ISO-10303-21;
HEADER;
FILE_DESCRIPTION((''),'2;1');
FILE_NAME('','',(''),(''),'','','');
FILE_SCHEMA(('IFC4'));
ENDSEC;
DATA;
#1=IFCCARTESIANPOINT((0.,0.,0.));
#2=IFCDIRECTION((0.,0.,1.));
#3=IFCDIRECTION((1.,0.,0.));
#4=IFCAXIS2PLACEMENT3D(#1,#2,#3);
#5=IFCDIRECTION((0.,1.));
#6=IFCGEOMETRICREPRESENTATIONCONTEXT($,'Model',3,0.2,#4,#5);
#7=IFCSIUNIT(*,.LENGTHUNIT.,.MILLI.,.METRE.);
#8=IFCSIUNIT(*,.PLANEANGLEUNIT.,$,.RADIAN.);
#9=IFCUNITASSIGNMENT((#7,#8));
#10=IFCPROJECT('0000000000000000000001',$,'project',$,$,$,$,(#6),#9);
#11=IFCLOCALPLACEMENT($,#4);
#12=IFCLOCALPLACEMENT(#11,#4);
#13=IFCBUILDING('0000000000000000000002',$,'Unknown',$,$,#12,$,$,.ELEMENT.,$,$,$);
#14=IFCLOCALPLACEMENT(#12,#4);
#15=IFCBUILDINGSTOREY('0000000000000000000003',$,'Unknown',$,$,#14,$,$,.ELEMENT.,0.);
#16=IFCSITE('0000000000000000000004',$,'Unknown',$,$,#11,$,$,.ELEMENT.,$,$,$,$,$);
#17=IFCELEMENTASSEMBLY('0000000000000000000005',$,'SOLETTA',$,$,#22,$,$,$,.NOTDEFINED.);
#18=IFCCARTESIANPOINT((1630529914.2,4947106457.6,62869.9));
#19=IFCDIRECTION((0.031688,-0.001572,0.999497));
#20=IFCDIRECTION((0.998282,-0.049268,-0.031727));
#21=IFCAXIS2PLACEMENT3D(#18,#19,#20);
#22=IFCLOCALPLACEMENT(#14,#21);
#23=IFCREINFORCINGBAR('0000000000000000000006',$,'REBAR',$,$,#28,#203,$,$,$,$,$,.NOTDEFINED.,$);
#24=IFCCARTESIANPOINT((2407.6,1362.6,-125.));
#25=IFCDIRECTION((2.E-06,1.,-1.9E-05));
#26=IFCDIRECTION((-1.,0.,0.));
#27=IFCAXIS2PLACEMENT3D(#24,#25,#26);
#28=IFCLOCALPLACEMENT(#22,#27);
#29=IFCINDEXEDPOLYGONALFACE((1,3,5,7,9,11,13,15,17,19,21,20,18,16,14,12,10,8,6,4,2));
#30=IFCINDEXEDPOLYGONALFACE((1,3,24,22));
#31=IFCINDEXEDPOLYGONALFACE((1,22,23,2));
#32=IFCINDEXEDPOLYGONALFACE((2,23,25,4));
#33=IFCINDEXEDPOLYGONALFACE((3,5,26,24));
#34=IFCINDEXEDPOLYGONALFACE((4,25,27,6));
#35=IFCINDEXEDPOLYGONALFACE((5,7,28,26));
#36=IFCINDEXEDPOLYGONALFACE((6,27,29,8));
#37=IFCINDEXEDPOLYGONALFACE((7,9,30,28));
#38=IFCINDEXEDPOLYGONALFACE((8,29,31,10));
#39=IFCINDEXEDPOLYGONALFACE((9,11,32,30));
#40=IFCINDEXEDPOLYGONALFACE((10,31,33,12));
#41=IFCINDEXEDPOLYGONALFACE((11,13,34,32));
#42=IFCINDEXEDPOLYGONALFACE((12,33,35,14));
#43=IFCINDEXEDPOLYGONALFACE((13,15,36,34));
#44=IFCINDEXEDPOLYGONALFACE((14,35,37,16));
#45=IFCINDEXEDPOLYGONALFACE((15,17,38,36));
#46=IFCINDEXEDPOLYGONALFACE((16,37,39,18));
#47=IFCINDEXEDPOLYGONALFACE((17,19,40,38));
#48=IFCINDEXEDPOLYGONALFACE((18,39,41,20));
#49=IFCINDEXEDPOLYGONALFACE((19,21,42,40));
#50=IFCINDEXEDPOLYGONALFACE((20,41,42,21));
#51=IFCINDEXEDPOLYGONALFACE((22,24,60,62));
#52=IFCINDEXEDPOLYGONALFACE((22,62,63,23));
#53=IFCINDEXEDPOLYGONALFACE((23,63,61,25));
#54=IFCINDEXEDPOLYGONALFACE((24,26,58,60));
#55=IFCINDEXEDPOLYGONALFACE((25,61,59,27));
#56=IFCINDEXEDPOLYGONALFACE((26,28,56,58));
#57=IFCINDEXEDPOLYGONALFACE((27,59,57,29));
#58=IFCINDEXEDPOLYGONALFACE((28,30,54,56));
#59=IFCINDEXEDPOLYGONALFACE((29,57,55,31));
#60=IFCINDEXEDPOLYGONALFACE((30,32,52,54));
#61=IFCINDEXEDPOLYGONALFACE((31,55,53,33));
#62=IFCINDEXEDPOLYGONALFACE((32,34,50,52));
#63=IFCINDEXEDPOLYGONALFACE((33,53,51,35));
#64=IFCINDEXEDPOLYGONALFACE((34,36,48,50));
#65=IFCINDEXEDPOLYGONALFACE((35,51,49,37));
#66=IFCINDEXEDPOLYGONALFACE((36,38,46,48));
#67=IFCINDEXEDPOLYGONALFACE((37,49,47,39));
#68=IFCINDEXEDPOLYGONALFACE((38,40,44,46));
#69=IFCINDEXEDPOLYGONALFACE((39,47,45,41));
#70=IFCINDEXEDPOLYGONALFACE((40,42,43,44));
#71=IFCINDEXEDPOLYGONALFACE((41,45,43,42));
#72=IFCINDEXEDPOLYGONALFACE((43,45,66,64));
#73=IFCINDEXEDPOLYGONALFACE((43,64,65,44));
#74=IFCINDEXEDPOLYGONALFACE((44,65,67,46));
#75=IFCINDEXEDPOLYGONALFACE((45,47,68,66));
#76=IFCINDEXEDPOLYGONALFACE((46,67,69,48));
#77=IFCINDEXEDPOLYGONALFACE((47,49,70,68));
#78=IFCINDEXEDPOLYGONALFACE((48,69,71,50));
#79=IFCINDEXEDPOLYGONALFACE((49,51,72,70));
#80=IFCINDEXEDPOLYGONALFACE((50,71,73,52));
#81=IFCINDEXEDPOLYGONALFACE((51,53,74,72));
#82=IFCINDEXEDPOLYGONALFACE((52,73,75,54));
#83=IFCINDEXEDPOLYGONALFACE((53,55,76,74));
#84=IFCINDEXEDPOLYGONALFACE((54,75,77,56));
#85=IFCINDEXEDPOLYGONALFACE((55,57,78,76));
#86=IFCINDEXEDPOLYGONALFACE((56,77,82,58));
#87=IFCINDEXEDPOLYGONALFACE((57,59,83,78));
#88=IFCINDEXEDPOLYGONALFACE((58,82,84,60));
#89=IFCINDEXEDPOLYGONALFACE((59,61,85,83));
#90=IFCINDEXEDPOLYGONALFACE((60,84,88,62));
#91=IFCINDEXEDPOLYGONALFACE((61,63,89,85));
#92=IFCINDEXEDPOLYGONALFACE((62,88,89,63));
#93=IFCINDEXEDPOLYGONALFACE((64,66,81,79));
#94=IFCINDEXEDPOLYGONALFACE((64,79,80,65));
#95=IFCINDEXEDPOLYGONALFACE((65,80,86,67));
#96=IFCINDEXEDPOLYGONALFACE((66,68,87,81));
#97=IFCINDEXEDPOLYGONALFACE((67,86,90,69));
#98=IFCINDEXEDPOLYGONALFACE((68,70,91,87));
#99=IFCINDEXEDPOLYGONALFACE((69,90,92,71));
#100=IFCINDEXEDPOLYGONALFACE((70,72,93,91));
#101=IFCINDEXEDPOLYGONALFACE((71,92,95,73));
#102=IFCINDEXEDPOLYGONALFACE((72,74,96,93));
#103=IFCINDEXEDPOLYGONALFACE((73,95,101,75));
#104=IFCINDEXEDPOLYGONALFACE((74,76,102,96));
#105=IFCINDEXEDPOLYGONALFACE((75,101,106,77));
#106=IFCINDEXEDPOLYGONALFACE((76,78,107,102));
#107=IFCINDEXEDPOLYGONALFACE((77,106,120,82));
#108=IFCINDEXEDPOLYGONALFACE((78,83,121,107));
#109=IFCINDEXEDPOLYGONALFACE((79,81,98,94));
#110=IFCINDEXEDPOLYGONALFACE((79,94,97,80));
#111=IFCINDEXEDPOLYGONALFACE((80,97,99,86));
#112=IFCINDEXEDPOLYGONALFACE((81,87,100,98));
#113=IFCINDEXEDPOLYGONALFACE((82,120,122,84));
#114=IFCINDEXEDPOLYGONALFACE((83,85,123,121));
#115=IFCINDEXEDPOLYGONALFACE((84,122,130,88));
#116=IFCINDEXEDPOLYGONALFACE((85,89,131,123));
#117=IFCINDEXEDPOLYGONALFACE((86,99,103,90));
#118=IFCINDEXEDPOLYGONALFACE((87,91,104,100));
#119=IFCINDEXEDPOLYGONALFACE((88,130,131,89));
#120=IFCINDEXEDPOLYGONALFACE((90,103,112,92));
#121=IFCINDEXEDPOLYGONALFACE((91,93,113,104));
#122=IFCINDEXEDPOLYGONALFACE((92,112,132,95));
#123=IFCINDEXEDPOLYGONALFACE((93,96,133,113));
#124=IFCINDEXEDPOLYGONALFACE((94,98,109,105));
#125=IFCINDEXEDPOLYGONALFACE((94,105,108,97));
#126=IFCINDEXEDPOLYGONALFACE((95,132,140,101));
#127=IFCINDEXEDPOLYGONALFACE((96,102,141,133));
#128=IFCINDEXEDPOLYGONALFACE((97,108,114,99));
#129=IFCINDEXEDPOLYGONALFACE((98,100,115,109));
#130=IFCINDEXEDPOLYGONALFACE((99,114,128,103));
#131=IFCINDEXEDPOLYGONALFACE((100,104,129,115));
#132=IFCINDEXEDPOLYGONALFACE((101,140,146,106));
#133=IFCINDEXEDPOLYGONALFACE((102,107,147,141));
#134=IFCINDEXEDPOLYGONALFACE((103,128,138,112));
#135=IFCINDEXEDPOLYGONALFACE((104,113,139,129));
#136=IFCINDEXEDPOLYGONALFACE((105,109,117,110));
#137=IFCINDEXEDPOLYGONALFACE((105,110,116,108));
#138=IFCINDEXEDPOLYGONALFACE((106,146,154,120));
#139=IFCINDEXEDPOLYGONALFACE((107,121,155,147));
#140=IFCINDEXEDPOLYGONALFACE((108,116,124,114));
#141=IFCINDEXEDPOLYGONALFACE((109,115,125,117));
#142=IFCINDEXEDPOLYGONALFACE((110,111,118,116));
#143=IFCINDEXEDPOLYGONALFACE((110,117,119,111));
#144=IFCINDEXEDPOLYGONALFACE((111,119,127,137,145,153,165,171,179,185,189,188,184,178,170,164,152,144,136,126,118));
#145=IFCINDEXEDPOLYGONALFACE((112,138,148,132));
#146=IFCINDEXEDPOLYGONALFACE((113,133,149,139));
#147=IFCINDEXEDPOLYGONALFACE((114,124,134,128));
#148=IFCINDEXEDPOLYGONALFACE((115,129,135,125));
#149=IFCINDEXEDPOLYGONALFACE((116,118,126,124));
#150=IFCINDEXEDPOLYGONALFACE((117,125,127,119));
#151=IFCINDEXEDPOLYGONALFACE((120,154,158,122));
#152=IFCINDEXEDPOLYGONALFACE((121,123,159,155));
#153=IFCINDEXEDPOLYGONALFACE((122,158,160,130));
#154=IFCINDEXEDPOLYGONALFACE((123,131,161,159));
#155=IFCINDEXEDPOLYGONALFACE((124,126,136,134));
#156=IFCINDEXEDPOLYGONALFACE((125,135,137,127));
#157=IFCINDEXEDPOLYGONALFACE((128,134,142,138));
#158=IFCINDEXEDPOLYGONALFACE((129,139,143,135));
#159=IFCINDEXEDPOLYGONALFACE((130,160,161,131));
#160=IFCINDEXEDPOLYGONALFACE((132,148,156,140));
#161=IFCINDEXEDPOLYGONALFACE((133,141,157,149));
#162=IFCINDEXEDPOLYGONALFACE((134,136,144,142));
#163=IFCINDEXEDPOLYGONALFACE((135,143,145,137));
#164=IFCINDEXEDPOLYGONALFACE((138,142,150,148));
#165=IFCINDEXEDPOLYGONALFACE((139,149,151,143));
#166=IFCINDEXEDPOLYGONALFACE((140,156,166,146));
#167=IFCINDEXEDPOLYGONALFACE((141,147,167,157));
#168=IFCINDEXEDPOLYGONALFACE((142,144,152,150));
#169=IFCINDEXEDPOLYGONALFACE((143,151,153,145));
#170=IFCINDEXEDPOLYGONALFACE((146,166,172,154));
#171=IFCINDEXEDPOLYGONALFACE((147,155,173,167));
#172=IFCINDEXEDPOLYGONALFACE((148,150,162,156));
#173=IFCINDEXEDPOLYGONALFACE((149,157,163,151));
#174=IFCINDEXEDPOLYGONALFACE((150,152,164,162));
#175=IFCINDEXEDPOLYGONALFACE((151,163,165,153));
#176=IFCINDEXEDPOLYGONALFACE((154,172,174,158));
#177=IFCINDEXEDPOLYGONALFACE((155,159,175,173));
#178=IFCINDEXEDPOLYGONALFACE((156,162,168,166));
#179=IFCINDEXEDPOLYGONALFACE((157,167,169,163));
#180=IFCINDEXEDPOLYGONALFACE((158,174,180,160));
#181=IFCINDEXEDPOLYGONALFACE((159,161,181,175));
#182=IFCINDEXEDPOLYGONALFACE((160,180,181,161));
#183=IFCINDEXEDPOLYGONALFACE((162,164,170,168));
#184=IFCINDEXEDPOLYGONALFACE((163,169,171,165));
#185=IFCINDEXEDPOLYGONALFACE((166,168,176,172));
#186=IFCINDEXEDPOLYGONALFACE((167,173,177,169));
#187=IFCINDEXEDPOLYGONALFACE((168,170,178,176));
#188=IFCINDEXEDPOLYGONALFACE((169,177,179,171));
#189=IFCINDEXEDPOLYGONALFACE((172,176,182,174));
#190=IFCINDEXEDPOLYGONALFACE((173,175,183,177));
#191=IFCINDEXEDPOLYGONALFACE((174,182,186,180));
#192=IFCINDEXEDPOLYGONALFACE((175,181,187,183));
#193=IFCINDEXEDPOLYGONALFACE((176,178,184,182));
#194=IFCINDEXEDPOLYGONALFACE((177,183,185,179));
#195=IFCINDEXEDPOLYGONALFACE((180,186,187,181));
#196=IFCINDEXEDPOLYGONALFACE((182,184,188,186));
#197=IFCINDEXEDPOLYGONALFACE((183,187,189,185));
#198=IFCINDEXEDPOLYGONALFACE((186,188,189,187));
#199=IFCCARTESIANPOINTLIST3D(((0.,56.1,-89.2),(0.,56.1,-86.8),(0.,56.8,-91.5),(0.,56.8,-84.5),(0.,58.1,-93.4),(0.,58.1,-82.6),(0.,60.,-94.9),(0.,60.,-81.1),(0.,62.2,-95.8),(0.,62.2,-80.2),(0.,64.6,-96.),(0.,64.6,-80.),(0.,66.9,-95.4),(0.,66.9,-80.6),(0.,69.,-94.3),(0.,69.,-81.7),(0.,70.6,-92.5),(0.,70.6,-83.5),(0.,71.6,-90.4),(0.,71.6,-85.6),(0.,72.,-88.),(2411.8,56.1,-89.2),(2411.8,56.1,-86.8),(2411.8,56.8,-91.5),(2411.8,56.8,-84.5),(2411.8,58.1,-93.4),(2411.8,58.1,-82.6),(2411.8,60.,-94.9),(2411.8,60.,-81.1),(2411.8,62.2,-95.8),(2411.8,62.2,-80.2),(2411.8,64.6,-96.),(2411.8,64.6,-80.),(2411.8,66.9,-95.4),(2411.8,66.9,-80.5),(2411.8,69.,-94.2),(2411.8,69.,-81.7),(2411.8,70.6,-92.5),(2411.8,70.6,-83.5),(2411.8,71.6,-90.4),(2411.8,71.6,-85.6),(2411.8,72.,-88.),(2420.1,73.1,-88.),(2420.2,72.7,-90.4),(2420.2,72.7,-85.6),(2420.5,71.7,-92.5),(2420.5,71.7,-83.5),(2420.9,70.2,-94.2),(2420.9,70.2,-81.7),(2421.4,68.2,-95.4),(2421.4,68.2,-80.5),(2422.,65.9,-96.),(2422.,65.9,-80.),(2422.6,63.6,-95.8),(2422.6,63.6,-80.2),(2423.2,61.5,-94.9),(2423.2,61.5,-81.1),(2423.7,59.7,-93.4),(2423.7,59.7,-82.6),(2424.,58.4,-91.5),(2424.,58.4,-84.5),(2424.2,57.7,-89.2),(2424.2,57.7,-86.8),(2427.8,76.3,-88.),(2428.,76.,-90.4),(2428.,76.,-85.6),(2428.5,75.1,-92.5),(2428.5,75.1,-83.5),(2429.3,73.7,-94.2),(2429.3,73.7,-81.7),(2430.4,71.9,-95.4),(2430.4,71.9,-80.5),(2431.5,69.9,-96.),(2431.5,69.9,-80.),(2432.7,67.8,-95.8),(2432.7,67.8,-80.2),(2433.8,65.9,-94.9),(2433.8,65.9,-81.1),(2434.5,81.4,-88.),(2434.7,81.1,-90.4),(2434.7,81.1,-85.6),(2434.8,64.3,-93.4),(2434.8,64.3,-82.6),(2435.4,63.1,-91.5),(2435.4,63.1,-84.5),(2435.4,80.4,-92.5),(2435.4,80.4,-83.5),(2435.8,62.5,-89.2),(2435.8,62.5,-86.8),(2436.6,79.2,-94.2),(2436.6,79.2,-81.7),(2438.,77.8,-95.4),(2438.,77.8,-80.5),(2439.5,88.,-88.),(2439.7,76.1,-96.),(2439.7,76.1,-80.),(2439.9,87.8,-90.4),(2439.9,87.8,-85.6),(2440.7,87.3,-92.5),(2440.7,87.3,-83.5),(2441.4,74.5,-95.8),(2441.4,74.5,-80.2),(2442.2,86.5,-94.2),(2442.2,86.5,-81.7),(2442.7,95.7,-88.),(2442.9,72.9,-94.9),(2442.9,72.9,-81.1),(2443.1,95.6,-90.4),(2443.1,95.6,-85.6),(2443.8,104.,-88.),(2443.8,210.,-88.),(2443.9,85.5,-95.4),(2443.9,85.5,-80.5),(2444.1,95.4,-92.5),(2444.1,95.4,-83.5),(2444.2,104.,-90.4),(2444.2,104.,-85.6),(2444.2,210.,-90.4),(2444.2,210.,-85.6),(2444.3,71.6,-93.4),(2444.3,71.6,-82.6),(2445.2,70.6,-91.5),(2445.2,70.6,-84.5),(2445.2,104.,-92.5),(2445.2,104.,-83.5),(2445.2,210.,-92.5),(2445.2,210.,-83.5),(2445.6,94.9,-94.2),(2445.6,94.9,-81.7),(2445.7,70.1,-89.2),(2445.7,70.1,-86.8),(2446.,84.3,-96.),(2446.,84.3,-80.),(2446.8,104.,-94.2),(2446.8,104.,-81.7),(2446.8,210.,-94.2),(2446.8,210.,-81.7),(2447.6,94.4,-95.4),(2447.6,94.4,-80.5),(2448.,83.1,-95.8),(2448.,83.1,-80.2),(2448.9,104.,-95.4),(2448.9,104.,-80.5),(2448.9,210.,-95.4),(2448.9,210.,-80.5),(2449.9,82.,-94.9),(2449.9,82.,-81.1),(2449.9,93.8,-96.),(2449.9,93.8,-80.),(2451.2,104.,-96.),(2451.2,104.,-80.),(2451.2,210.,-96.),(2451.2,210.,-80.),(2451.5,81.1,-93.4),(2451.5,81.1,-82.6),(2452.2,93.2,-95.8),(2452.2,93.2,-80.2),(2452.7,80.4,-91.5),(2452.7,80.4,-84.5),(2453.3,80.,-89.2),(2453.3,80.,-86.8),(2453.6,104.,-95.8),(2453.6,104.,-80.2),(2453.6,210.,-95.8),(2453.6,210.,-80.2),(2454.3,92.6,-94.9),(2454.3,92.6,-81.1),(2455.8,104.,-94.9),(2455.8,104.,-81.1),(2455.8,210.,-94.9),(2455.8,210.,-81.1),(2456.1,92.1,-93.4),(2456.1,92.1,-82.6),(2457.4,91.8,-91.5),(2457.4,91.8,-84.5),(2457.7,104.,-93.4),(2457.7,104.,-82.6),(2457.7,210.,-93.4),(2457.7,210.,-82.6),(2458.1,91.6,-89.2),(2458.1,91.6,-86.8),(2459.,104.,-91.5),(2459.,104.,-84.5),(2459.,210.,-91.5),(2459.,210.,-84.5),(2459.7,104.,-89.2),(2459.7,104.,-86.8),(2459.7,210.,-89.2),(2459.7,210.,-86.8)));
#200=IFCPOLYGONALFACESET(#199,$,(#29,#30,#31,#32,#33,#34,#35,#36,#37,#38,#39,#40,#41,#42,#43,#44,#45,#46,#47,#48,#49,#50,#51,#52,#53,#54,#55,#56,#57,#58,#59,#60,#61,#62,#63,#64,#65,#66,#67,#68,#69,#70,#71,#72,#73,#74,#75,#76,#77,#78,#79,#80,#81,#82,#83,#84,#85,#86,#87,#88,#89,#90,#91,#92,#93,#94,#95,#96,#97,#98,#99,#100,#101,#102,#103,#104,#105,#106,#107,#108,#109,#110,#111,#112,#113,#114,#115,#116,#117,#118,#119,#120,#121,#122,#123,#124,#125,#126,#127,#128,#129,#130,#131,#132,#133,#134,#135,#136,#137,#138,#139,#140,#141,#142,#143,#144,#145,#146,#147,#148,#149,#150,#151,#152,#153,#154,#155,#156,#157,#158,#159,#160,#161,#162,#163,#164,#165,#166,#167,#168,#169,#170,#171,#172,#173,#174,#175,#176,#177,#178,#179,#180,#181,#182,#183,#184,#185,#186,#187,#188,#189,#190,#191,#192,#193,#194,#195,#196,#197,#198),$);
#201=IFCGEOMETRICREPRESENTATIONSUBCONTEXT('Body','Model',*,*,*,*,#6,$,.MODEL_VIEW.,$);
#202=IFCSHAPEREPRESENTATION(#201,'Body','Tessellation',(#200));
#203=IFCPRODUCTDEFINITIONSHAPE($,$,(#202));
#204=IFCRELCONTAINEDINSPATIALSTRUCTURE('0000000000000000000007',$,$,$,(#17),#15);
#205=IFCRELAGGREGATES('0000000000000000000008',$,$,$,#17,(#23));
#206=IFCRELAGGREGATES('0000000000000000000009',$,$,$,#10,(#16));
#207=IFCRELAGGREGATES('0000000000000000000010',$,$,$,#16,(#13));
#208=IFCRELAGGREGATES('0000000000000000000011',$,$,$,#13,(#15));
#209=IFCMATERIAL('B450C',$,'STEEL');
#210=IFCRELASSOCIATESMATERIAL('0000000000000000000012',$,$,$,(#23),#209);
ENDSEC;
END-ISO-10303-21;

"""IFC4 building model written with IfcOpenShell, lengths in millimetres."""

from ifc_helpers import new_model, entity, si_unit, direction, frame, origin_with_axes, place, context, subcontext, project, spatial, material, element, aggregate, save


model = new_model("IFC4")

# Units and contexts
model_context = context("Model", 3, precision=0.2, world=origin_with_axes(), true_north=direction((0.0, 1.0)))
body_context = subcontext(model_context, "Body", "Model", "MODEL_VIEW")
ifc_project = project(units=[si_unit("LENGTHUNIT", "METRE", prefix="MILLI"), si_unit("PLANEANGLEUNIT", "RADIAN")], contexts=[model_context])

# Site, building, storey
site_placement = place(None, origin_with_axes())
site = spatial("IfcSite", under=ifc_project, at=site_placement, Name="Unknown", CompositionType="ELEMENT")
building_placement = place(site_placement, origin_with_axes())
building = spatial("IfcBuilding", under=site, at=building_placement, Name="Unknown", CompositionType="ELEMENT")
storey_placement = place(building_placement, origin_with_axes())
storey = spatial("IfcBuildingStorey", under=building, at=storey_placement, Name="Unknown", CompositionType="ELEMENT", Elevation=0.0)

# Element assembly
ifc_material = material(Name="B450C", Category="STEEL")
assembly_1_placement = place(storey_placement, frame((1630529914.2, 4947106457.6, 62869.9), z_axis=(0.031688, -0.001572, 0.999497), x_axis=(0.998282, -0.049268, -0.031727)))
assembly_1 = element("IfcElementAssembly", 1, at=assembly_1_placement, inside=storey, Name="SOLETTA", PredefinedType="NOTDEFINED")

# Reinforcing bar
reinforcing_bar_1_placement = place(assembly_1_placement, frame((2407.6, 1362.6, -125.0), z_axis=(0.000002, 1.0, -0.000019), x_axis=(-1.0, 0.0, 0.0)))
reinforcing_bar_1 = element("IfcReinforcingBar", 2, at=reinforcing_bar_1_placement, material=ifc_material, Name="REBAR", PredefinedType="NOTDEFINED", context=body_context, shape_type="AdvancedSweptSolid", body=[
    entity("IfcSweptDiskSolid", entity("IfcIndexedPolyCurve", entity("IfcCartesianPointList3D", [[0.0, 64.0, -88.0], [2411.8, 64.0, -88.0], [2440.1, 75.7, -88.0], [2451.8, 104.0, -88.0], [2451.8, 210.0, -88.0]]), [entity("IfcLineIndex", [1, 2]), entity("IfcArcIndex", [2, 3, 4]), entity("IfcLineIndex", [4, 5])]), 8.0),
])
aggregate(assembly_1, [reinforcing_bar_1])

save(model, "model.ifc")
